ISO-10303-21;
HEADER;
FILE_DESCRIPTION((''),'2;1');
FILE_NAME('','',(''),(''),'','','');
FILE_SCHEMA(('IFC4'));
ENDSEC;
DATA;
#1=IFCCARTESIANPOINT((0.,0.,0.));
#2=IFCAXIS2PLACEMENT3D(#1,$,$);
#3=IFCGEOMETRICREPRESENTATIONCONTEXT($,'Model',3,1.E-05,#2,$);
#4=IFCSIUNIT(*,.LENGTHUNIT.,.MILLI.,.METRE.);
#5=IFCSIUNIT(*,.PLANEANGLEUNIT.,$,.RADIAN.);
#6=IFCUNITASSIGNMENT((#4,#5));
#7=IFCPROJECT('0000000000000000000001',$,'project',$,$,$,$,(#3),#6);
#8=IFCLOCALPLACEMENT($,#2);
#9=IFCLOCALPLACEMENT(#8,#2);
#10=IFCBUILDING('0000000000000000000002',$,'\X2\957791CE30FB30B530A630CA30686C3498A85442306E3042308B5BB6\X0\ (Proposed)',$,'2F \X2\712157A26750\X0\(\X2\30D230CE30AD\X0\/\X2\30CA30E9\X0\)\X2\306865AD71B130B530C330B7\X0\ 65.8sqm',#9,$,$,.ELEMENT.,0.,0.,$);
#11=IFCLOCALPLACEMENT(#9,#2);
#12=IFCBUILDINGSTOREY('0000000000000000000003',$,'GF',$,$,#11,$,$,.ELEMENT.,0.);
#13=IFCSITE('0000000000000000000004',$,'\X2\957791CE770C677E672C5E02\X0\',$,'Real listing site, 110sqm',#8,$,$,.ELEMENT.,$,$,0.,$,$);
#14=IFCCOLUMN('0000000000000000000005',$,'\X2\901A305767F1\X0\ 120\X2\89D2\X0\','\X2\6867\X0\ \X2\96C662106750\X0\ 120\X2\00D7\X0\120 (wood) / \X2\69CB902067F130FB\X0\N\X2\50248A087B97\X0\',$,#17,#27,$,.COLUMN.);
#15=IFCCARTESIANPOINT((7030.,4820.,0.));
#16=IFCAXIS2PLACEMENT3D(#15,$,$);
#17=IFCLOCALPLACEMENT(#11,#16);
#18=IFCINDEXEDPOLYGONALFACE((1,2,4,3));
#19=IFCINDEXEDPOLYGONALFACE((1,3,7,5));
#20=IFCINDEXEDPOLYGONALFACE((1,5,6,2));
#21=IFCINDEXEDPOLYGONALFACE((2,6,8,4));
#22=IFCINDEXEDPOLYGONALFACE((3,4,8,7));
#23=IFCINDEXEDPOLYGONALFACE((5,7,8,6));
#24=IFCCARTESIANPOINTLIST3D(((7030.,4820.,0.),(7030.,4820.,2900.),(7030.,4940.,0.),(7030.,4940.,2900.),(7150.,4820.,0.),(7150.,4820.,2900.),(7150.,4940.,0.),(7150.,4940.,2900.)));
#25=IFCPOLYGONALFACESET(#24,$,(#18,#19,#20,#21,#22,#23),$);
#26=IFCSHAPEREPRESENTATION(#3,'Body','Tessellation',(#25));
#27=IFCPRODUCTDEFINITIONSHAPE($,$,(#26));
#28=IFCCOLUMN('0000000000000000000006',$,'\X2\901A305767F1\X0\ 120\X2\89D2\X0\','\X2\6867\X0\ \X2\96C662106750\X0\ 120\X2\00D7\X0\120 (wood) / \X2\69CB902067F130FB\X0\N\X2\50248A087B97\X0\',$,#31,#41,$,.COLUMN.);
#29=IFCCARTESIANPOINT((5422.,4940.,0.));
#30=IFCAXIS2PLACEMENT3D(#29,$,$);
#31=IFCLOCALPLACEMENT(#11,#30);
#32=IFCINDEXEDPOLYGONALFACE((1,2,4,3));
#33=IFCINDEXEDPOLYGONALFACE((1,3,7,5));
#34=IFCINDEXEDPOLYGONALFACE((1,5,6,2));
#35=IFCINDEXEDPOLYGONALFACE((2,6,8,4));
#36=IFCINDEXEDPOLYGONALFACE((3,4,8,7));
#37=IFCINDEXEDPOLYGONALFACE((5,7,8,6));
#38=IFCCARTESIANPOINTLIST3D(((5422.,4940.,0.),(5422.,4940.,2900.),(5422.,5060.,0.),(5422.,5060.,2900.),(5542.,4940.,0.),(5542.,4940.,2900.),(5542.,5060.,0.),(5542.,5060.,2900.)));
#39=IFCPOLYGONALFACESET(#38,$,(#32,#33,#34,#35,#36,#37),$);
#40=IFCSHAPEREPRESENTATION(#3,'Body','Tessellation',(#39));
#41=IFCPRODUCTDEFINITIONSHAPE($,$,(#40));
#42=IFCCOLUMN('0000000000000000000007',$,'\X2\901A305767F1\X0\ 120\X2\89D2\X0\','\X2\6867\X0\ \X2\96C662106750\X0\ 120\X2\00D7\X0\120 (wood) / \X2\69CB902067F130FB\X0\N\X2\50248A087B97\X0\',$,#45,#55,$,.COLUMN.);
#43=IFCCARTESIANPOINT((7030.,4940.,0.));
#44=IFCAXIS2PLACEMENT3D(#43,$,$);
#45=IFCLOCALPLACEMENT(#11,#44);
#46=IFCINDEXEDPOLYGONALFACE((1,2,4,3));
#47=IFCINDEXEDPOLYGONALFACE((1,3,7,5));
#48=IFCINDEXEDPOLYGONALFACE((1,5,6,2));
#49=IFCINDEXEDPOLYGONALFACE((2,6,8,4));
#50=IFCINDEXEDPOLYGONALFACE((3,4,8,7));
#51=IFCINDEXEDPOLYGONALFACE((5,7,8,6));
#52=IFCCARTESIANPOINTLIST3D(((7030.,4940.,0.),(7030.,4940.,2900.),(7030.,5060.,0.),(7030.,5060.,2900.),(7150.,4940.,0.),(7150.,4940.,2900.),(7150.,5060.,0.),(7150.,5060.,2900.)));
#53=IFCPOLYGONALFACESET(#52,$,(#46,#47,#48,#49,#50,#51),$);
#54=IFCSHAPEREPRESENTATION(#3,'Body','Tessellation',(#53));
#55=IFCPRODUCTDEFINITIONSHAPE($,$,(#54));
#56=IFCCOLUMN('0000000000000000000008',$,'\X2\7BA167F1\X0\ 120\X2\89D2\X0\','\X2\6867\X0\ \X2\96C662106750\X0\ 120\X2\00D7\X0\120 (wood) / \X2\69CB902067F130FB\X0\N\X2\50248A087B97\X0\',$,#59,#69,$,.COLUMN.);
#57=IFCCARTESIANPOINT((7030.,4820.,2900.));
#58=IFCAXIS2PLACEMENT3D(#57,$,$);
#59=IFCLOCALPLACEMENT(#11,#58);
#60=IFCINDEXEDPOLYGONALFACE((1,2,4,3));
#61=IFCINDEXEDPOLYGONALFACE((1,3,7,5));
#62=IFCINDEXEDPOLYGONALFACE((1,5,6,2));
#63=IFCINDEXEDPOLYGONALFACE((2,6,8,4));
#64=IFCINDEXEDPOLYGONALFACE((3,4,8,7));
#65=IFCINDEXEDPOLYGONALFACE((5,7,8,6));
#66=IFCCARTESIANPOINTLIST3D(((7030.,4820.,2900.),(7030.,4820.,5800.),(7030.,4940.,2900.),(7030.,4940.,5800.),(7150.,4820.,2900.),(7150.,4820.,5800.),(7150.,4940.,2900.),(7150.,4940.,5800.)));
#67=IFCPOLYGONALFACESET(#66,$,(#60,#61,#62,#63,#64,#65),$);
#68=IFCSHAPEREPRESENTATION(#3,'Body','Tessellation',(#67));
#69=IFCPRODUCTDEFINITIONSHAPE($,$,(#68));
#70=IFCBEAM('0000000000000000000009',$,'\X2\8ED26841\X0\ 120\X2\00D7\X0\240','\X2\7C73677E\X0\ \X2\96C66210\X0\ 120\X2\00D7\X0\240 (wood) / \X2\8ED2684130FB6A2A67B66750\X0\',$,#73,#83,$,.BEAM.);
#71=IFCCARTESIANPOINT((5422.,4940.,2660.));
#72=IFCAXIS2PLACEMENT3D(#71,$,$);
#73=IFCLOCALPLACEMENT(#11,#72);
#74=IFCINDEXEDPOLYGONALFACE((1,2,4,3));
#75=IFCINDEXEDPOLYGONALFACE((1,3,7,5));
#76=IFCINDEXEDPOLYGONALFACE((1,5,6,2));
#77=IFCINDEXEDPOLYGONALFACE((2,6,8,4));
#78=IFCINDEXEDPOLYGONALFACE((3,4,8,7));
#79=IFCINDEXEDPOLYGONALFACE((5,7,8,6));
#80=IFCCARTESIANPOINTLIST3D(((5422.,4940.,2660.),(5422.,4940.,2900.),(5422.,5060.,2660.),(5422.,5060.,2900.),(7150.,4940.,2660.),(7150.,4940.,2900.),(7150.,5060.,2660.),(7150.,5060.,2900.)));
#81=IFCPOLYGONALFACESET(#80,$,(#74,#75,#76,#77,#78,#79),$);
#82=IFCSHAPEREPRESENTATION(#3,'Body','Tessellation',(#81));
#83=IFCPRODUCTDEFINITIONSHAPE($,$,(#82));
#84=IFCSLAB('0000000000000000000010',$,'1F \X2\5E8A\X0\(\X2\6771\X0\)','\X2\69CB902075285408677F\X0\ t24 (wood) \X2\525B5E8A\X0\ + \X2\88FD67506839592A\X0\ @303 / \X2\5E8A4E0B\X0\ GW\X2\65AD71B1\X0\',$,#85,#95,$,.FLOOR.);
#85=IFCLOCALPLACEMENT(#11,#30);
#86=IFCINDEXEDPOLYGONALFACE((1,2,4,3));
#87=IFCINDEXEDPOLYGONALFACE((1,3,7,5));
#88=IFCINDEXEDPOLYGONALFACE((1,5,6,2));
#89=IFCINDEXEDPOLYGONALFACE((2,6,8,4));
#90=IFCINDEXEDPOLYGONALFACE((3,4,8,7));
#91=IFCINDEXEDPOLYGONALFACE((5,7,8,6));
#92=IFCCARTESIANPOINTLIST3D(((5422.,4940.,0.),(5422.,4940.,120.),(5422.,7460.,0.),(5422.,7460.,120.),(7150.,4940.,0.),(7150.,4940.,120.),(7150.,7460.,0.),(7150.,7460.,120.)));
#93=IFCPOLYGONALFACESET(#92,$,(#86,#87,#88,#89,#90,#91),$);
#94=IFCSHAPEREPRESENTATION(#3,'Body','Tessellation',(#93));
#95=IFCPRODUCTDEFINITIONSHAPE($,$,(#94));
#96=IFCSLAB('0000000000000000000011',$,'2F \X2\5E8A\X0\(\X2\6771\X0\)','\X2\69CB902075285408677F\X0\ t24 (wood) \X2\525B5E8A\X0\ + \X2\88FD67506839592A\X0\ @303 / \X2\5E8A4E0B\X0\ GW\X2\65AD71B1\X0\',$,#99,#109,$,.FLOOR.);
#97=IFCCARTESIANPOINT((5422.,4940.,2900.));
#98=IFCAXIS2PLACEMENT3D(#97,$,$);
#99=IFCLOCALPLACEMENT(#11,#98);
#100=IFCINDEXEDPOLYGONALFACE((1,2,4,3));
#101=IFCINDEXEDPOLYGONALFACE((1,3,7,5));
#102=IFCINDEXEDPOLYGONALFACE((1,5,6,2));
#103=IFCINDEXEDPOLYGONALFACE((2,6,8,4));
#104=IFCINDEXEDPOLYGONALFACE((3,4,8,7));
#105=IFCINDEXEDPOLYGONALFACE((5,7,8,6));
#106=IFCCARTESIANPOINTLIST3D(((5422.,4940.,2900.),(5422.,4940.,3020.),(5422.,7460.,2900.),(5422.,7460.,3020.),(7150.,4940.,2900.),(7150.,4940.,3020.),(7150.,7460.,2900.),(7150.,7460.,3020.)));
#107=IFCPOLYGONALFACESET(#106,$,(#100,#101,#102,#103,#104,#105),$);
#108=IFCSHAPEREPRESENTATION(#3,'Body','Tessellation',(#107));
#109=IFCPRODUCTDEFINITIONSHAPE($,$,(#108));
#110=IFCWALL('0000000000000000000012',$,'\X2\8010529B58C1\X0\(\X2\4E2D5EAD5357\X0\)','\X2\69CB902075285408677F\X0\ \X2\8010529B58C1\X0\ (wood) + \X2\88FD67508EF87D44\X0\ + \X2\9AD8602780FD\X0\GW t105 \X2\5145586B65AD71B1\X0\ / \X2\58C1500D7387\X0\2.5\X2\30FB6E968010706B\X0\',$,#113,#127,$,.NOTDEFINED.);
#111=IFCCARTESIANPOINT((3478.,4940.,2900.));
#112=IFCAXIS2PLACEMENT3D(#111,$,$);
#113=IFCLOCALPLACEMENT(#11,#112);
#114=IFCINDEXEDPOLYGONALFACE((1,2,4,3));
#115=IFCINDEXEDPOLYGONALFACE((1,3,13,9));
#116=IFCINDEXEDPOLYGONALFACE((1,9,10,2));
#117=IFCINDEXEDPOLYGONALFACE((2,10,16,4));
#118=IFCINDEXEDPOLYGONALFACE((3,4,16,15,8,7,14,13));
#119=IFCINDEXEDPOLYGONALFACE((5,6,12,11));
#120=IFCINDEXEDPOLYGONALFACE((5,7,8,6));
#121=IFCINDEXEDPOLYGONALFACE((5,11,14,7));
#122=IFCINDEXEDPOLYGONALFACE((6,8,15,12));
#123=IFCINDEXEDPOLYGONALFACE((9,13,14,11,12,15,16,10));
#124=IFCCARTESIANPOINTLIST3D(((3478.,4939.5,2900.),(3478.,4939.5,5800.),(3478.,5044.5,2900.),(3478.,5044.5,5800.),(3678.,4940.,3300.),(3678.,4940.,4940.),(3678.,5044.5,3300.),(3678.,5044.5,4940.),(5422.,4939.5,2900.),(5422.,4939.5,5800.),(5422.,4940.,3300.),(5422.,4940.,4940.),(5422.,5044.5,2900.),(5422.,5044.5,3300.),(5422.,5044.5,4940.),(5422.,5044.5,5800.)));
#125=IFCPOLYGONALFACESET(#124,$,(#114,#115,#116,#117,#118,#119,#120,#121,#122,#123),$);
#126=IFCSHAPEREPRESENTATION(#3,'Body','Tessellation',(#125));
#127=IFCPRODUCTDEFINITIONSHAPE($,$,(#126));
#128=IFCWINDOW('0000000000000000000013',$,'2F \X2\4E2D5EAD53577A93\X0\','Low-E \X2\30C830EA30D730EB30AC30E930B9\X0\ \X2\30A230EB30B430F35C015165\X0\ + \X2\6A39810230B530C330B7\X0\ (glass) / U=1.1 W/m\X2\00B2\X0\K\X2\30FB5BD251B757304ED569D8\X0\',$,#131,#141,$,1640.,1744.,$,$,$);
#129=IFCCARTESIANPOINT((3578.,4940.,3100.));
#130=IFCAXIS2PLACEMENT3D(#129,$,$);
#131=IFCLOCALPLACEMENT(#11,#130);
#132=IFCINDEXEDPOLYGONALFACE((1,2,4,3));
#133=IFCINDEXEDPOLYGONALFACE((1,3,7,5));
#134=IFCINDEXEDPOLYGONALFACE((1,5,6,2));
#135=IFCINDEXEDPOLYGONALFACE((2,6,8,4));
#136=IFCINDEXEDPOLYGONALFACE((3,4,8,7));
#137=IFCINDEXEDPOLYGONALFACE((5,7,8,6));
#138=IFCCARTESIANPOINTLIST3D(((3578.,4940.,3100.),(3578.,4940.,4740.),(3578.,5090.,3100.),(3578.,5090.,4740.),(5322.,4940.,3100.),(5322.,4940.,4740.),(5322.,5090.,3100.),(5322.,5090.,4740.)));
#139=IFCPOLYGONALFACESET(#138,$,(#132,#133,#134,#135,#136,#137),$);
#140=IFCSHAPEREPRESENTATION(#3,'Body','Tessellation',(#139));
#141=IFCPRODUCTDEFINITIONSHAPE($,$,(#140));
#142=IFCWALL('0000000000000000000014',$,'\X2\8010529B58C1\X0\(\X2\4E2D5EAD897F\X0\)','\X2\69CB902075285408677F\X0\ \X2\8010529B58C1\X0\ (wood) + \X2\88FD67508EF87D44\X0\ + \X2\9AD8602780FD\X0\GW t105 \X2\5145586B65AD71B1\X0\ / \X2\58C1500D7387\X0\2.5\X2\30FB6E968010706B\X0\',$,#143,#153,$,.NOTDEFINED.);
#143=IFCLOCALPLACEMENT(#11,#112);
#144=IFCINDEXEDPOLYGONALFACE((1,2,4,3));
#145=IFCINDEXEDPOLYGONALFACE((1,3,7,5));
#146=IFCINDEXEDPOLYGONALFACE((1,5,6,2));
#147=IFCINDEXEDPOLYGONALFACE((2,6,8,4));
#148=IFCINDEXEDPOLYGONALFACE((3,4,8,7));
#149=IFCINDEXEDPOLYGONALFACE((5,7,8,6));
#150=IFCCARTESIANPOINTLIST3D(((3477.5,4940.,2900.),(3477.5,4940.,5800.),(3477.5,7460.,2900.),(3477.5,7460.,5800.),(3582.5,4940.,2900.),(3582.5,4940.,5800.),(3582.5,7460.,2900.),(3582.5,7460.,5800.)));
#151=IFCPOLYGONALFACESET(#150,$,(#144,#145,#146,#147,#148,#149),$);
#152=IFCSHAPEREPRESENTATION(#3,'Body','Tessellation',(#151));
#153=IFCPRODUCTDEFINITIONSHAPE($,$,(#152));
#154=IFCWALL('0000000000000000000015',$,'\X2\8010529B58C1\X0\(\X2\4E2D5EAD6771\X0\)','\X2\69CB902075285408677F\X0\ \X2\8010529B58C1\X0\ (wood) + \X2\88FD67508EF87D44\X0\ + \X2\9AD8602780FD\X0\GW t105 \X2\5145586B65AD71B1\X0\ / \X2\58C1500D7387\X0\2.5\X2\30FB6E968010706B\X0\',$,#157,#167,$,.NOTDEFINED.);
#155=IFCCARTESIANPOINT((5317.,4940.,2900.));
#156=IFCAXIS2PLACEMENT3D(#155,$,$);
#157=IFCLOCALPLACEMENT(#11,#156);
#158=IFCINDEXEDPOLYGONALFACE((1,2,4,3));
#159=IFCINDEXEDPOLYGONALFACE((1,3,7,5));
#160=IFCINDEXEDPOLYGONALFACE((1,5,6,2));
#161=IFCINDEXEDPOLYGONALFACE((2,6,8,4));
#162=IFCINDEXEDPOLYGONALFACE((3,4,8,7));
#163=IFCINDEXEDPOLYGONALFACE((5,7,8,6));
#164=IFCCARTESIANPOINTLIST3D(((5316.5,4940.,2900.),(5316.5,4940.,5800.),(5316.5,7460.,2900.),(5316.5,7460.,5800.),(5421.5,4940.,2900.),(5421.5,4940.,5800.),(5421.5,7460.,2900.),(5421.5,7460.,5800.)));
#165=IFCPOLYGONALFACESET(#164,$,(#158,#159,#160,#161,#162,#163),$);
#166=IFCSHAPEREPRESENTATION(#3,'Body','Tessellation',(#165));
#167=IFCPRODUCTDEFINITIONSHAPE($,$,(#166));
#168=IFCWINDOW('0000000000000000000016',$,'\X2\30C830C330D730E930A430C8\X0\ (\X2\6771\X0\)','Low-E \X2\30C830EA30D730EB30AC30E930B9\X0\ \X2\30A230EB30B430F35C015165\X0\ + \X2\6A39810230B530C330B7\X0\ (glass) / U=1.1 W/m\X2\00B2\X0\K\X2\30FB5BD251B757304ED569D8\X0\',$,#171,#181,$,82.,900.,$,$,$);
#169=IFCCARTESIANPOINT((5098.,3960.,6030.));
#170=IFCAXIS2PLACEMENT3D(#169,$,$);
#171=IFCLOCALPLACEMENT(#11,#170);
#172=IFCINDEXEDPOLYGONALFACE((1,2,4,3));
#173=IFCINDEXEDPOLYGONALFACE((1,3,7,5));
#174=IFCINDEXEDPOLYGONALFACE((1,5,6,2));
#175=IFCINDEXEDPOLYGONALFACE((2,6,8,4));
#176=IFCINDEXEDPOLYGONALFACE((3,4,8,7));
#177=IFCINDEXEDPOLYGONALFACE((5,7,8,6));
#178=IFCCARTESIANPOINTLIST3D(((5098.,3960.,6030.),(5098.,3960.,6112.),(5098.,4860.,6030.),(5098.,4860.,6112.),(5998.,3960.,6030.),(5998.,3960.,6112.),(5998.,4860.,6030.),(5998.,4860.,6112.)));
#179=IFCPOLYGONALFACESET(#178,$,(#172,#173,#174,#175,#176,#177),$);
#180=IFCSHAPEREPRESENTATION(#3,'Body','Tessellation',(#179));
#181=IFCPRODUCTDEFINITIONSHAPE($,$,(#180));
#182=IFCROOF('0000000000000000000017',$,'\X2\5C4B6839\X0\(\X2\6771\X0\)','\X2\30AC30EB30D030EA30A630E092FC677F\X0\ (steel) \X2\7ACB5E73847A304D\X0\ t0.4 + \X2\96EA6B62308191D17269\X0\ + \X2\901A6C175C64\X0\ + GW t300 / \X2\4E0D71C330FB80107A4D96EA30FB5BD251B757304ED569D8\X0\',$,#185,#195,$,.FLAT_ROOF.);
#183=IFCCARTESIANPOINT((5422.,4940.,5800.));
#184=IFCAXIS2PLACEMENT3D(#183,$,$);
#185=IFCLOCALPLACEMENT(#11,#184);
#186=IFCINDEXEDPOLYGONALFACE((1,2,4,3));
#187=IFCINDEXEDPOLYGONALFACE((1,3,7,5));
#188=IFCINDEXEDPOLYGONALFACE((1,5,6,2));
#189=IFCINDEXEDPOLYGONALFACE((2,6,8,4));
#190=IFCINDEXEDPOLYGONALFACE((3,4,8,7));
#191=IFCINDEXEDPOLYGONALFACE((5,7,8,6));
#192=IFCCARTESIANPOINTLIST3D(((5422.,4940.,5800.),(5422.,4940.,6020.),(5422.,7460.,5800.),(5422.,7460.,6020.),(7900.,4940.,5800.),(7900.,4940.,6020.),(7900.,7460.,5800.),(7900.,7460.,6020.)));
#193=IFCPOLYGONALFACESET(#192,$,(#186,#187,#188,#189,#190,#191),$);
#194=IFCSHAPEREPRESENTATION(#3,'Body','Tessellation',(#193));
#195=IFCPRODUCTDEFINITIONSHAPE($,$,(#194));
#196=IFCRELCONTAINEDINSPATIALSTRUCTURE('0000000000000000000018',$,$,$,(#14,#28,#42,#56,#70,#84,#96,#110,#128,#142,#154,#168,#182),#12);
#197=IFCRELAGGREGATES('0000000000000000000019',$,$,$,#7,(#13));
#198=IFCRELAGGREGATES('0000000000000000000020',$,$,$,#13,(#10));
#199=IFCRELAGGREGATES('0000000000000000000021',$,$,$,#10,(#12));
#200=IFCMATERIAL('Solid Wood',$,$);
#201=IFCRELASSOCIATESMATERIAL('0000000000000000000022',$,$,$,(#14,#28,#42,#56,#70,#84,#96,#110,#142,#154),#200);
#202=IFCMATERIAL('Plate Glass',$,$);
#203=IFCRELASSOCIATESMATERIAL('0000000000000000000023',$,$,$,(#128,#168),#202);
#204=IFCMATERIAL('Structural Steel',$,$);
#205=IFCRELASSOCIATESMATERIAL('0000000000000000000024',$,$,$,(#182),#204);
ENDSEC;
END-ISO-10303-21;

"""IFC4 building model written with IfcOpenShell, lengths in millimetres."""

from ifc_helpers import new_model, si_unit, frame, frame_2d, origin, place, context, project, spatial, rectangle, extrude, material, element, fill, save


model = new_model("IFC4")

# Units and contexts
model_context = context("Model", 3, precision=1e-05, world=origin())
ifc_project = project(units=[si_unit("LENGTHUNIT", "METRE", prefix="MILLI"), si_unit("PLANEANGLEUNIT", "RADIAN")], contexts=[model_context])

# Site, building, storey
site_placement = place(None, origin())
site = spatial("IfcSite", under=ifc_project, at=site_placement, Name="長野県松本市", ObjectType="Real listing site, 110sqm", CompositionType="ELEMENT", RefElevation=0.0)
building_placement = place(site_placement, origin())
building = spatial("IfcBuilding", under=site, at=building_placement, Name="長野・サウナと水風呂のある家 (Proposed)", ObjectType="2F 無垢材(ヒノキ/ナラ)と断熱サッシ 65.8sqm", CompositionType="ELEMENT", ElevationOfRefHeight=0.0, ElevationOfTerrain=0.0)
storey_placement = place(building_placement, origin())
storey = spatial("IfcBuildingStorey", under=building, at=storey_placement, Name="GF", CompositionType="ELEMENT", Elevation=0.0)

# Columns
ifc_material_1 = material(Name="Solid Wood")
column_1_placement = place(storey_placement, frame((7030.0, 4820.0, 0.0)))
element("IfcColumn", 1, at=column_1_placement, inside=storey, material=ifc_material_1, Name="通し柱 120角", Description="桧 集成材 120×120 (wood) / 構造柱・N値計算", PredefinedType="COLUMN", context=model_context, shape_type="SweptSolid", body=[
    extrude(rectangle(XDim=120.0, YDim=120.0, at=frame_2d((60.0, 60.0))), frame((7030.0, 4820.0, 0.0)), (0.0, 0.0, 1.0), 2900.0),
])
column_2_placement = place(storey_placement, frame((5422.0, 4940.0, 0.0)))
element("IfcColumn", 2, at=column_2_placement, inside=storey, material=ifc_material_1, Name="通し柱 120角", Description="桧 集成材 120×120 (wood) / 構造柱・N値計算", PredefinedType="COLUMN", context=model_context, shape_type="SweptSolid", body=[
    extrude(rectangle(XDim=120.0, YDim=120.0, at=frame_2d((60.0, 60.0))), frame((5422.0, 4940.0, 0.0)), (0.0, 0.0, 1.0), 2900.0),
])
column_3_placement = place(storey_placement, frame((7030.0, 4940.0, 0.0)))
element("IfcColumn", 3, at=column_3_placement, inside=storey, material=ifc_material_1, Name="通し柱 120角", Description="桧 集成材 120×120 (wood) / 構造柱・N値計算", PredefinedType="COLUMN", context=model_context, shape_type="SweptSolid", body=[
    extrude(rectangle(XDim=120.0, YDim=120.0, at=frame_2d((60.0, 60.0))), frame((7030.0, 4940.0, 0.0)), (0.0, 0.0, 1.0), 2900.0),
])
column_4_placement = place(storey_placement, frame((7030.0, 4820.0, 2900.0)))
element("IfcColumn", 4, at=column_4_placement, inside=storey, material=ifc_material_1, Name="管柱 120角", Description="桧 集成材 120×120 (wood) / 構造柱・N値計算", PredefinedType="COLUMN", context=model_context, shape_type="SweptSolid", body=[
    extrude(rectangle(XDim=120.0, YDim=120.0, at=frame_2d((60.0, 60.0))), frame((7030.0, 4820.0, 2900.0)), (0.0, 0.0, 1.0), 2900.0),
])

# Beam
beam_1_placement = place(storey_placement, frame((5422.0, 4940.0, 2660.0)))
element("IfcBeam", 5, at=beam_1_placement, inside=storey, material=ifc_material_1, Name="軒桁 120×240", Description="米松 集成 120×240 (wood) / 軒桁・横架材", PredefinedType="BEAM", context=model_context, shape_type="SweptSolid", body=[
    extrude(rectangle(XDim=1728.0, YDim=120.0, at=frame_2d((864.0, 60.0))), frame((5422.0, 4940.0, 2660.0)), (0.0, 0.0, 1.0), 240.0),
])

# Slabs
slab_1_placement = place(storey_placement, frame((5422.0, 4940.0, 0.0)))
element("IfcSlab", 6, at=slab_1_placement, inside=storey, material=ifc_material_1, Name="1F 床(東)", Description="構造用合板 t24 (wood) 剛床 + 製材根太 @303 / 床下 GW断熱", PredefinedType="FLOOR", context=model_context, shape_type="SweptSolid", body=[
    extrude(rectangle(XDim=1728.0, YDim=2520.0, at=frame_2d((864.0, 1260.0))), frame((5422.0, 4940.0, 0.0)), (0.0, 0.0, 1.0), 120.0),
])
slab_2_placement = place(storey_placement, frame((5422.0, 4940.0, 2900.0)))
element("IfcSlab", 7, at=slab_2_placement, inside=storey, material=ifc_material_1, Name="2F 床(東)", Description="構造用合板 t24 (wood) 剛床 + 製材根太 @303 / 床下 GW断熱", PredefinedType="FLOOR", context=model_context, shape_type="SweptSolid", body=[
    extrude(rectangle(XDim=1728.0, YDim=2520.0, at=frame_2d((864.0, 1260.0))), frame((5422.0, 4940.0, 2900.0)), (0.0, 0.0, 1.0), 120.0),
])

# Wall, opening, window
wall_1_placement = place(storey_placement, frame((3478.0, 4940.0, 2900.0)))
wall_1 = element("IfcWall", 8, at=wall_1_placement, inside=storey, material=ifc_material_1, Name="耐力壁(中庭南)", Description="構造用合板 耐力壁 (wood) + 製材軸組 + 高性能GW t105 充填断熱 / 壁倍率2.5・準耐火", PredefinedType="NOTDEFINED", context=model_context, shape_type="SweptSolid", body=[
    extrude(rectangle(XDim=1944.0, YDim=105.0, at=frame_2d((972.0, 52.0))), frame((3478.0, 4940.0, 2900.0)), (0.0, 0.0, 1.0), 2900.0),
])
opening_placement = place(storey_placement, frame((3578.0, 4940.0, 3100.0)))
opening = element("IfcOpeningElement", 9, at=opening_placement, cuts=wall_1, PredefinedType="NOTDEFINED", context=model_context, shape_type="SweptSolid", body=[
    extrude(rectangle(XDim=1744.0, YDim=150.0, at=frame_2d((872.0, 75.0))), frame((3578.0, 4940.0, 3100.0)), (0.0, 0.0, 1.0), 1640.0),
])
ifc_material_2 = material(Name="Plate Glass")
window_1_placement = place(storey_placement, frame((3578.0, 4940.0, 3100.0)))
window_1 = element("IfcWindow", 10, at=window_1_placement, inside=storey, material=ifc_material_2, Name="2F 中庭南窓", Description="Low-E トリプルガラス アルゴン封入 + 樹脂サッシ (glass) / U=1.1 W/m²K・寒冷地仕様", OverallHeight=1640.0, OverallWidth=1744.0, context=model_context, shape_type="SweptSolid", body=[
    extrude(rectangle(XDim=1744.0, YDim=150.0, at=frame_2d((872.0, 75.0))), frame((3578.0, 4940.0, 3100.0)), (0.0, 0.0, 1.0), 1640.0),
])
fill(opening, window_1)

# Walls
wall_2_placement = place(storey_placement, frame((3478.0, 4940.0, 2900.0)))
element("IfcWall", 11, at=wall_2_placement, inside=storey, material=ifc_material_1, Name="耐力壁(中庭西)", Description="構造用合板 耐力壁 (wood) + 製材軸組 + 高性能GW t105 充填断熱 / 壁倍率2.5・準耐火", PredefinedType="NOTDEFINED", context=model_context, shape_type="SweptSolid", body=[
    extrude(rectangle(XDim=105.0, YDim=2520.0, at=frame_2d((52.0, 1260.0))), frame((3478.0, 4940.0, 2900.0)), (0.0, 0.0, 1.0), 2900.0),
])
wall_3_placement = place(storey_placement, frame((5317.0, 4940.0, 2900.0)))
element("IfcWall", 12, at=wall_3_placement, inside=storey, material=ifc_material_1, Name="耐力壁(中庭東)", Description="構造用合板 耐力壁 (wood) + 製材軸組 + 高性能GW t105 充填断熱 / 壁倍率2.5・準耐火", PredefinedType="NOTDEFINED", context=model_context, shape_type="SweptSolid", body=[
    extrude(rectangle(XDim=105.0, YDim=2520.0, at=frame_2d((52.0, 1260.0))), frame((5317.0, 4940.0, 2900.0)), (0.0, 0.0, 1.0), 2900.0),
])

# Window
window_2_placement = place(storey_placement, frame((5098.0, 3960.0, 6030.0)))
element("IfcWindow", 13, at=window_2_placement, inside=storey, material=ifc_material_2, Name="トップライト (東)", Description="Low-E トリプルガラス アルゴン封入 + 樹脂サッシ (glass) / U=1.1 W/m²K・寒冷地仕様", OverallHeight=82.0, OverallWidth=900.0, context=model_context, shape_type="SweptSolid", body=[
    extrude(rectangle(XDim=900.0, YDim=900.0, at=frame_2d((450.0, 450.0))), frame((5098.0, 3960.0, 6030.0)), (0.0, 0.0, 1.0), 82.0),
])

# Roof
ifc_material_3 = material(Name="Structural Steel")
for number, where, name in (
    (14, (5422.0, 4940.0, 5800.0), "屋根(東)"),
):
    element("IfcRoof", number, at=place(storey_placement, frame(where)), inside=storey, material=ifc_material_3, Name=name, Description="ガルバリウム鋼板 (steel) 立平葺き t0.4 + 雪止め金物 + 通気層 + GW t300 / 不燃・耐積雪・寒冷地仕様", PredefinedType="FLAT_ROOF", context=model_context, shape_type="SweptSolid", body=[
        extrude(rectangle(XDim=2478.0, YDim=2520.0, at=frame_2d((1239.0, 1260.0))), frame((5422.0, 4940.0, 5800.0)), (0.0, 0.0, 1.0), 220.0),
    ])

save(model, "model.ifc")
